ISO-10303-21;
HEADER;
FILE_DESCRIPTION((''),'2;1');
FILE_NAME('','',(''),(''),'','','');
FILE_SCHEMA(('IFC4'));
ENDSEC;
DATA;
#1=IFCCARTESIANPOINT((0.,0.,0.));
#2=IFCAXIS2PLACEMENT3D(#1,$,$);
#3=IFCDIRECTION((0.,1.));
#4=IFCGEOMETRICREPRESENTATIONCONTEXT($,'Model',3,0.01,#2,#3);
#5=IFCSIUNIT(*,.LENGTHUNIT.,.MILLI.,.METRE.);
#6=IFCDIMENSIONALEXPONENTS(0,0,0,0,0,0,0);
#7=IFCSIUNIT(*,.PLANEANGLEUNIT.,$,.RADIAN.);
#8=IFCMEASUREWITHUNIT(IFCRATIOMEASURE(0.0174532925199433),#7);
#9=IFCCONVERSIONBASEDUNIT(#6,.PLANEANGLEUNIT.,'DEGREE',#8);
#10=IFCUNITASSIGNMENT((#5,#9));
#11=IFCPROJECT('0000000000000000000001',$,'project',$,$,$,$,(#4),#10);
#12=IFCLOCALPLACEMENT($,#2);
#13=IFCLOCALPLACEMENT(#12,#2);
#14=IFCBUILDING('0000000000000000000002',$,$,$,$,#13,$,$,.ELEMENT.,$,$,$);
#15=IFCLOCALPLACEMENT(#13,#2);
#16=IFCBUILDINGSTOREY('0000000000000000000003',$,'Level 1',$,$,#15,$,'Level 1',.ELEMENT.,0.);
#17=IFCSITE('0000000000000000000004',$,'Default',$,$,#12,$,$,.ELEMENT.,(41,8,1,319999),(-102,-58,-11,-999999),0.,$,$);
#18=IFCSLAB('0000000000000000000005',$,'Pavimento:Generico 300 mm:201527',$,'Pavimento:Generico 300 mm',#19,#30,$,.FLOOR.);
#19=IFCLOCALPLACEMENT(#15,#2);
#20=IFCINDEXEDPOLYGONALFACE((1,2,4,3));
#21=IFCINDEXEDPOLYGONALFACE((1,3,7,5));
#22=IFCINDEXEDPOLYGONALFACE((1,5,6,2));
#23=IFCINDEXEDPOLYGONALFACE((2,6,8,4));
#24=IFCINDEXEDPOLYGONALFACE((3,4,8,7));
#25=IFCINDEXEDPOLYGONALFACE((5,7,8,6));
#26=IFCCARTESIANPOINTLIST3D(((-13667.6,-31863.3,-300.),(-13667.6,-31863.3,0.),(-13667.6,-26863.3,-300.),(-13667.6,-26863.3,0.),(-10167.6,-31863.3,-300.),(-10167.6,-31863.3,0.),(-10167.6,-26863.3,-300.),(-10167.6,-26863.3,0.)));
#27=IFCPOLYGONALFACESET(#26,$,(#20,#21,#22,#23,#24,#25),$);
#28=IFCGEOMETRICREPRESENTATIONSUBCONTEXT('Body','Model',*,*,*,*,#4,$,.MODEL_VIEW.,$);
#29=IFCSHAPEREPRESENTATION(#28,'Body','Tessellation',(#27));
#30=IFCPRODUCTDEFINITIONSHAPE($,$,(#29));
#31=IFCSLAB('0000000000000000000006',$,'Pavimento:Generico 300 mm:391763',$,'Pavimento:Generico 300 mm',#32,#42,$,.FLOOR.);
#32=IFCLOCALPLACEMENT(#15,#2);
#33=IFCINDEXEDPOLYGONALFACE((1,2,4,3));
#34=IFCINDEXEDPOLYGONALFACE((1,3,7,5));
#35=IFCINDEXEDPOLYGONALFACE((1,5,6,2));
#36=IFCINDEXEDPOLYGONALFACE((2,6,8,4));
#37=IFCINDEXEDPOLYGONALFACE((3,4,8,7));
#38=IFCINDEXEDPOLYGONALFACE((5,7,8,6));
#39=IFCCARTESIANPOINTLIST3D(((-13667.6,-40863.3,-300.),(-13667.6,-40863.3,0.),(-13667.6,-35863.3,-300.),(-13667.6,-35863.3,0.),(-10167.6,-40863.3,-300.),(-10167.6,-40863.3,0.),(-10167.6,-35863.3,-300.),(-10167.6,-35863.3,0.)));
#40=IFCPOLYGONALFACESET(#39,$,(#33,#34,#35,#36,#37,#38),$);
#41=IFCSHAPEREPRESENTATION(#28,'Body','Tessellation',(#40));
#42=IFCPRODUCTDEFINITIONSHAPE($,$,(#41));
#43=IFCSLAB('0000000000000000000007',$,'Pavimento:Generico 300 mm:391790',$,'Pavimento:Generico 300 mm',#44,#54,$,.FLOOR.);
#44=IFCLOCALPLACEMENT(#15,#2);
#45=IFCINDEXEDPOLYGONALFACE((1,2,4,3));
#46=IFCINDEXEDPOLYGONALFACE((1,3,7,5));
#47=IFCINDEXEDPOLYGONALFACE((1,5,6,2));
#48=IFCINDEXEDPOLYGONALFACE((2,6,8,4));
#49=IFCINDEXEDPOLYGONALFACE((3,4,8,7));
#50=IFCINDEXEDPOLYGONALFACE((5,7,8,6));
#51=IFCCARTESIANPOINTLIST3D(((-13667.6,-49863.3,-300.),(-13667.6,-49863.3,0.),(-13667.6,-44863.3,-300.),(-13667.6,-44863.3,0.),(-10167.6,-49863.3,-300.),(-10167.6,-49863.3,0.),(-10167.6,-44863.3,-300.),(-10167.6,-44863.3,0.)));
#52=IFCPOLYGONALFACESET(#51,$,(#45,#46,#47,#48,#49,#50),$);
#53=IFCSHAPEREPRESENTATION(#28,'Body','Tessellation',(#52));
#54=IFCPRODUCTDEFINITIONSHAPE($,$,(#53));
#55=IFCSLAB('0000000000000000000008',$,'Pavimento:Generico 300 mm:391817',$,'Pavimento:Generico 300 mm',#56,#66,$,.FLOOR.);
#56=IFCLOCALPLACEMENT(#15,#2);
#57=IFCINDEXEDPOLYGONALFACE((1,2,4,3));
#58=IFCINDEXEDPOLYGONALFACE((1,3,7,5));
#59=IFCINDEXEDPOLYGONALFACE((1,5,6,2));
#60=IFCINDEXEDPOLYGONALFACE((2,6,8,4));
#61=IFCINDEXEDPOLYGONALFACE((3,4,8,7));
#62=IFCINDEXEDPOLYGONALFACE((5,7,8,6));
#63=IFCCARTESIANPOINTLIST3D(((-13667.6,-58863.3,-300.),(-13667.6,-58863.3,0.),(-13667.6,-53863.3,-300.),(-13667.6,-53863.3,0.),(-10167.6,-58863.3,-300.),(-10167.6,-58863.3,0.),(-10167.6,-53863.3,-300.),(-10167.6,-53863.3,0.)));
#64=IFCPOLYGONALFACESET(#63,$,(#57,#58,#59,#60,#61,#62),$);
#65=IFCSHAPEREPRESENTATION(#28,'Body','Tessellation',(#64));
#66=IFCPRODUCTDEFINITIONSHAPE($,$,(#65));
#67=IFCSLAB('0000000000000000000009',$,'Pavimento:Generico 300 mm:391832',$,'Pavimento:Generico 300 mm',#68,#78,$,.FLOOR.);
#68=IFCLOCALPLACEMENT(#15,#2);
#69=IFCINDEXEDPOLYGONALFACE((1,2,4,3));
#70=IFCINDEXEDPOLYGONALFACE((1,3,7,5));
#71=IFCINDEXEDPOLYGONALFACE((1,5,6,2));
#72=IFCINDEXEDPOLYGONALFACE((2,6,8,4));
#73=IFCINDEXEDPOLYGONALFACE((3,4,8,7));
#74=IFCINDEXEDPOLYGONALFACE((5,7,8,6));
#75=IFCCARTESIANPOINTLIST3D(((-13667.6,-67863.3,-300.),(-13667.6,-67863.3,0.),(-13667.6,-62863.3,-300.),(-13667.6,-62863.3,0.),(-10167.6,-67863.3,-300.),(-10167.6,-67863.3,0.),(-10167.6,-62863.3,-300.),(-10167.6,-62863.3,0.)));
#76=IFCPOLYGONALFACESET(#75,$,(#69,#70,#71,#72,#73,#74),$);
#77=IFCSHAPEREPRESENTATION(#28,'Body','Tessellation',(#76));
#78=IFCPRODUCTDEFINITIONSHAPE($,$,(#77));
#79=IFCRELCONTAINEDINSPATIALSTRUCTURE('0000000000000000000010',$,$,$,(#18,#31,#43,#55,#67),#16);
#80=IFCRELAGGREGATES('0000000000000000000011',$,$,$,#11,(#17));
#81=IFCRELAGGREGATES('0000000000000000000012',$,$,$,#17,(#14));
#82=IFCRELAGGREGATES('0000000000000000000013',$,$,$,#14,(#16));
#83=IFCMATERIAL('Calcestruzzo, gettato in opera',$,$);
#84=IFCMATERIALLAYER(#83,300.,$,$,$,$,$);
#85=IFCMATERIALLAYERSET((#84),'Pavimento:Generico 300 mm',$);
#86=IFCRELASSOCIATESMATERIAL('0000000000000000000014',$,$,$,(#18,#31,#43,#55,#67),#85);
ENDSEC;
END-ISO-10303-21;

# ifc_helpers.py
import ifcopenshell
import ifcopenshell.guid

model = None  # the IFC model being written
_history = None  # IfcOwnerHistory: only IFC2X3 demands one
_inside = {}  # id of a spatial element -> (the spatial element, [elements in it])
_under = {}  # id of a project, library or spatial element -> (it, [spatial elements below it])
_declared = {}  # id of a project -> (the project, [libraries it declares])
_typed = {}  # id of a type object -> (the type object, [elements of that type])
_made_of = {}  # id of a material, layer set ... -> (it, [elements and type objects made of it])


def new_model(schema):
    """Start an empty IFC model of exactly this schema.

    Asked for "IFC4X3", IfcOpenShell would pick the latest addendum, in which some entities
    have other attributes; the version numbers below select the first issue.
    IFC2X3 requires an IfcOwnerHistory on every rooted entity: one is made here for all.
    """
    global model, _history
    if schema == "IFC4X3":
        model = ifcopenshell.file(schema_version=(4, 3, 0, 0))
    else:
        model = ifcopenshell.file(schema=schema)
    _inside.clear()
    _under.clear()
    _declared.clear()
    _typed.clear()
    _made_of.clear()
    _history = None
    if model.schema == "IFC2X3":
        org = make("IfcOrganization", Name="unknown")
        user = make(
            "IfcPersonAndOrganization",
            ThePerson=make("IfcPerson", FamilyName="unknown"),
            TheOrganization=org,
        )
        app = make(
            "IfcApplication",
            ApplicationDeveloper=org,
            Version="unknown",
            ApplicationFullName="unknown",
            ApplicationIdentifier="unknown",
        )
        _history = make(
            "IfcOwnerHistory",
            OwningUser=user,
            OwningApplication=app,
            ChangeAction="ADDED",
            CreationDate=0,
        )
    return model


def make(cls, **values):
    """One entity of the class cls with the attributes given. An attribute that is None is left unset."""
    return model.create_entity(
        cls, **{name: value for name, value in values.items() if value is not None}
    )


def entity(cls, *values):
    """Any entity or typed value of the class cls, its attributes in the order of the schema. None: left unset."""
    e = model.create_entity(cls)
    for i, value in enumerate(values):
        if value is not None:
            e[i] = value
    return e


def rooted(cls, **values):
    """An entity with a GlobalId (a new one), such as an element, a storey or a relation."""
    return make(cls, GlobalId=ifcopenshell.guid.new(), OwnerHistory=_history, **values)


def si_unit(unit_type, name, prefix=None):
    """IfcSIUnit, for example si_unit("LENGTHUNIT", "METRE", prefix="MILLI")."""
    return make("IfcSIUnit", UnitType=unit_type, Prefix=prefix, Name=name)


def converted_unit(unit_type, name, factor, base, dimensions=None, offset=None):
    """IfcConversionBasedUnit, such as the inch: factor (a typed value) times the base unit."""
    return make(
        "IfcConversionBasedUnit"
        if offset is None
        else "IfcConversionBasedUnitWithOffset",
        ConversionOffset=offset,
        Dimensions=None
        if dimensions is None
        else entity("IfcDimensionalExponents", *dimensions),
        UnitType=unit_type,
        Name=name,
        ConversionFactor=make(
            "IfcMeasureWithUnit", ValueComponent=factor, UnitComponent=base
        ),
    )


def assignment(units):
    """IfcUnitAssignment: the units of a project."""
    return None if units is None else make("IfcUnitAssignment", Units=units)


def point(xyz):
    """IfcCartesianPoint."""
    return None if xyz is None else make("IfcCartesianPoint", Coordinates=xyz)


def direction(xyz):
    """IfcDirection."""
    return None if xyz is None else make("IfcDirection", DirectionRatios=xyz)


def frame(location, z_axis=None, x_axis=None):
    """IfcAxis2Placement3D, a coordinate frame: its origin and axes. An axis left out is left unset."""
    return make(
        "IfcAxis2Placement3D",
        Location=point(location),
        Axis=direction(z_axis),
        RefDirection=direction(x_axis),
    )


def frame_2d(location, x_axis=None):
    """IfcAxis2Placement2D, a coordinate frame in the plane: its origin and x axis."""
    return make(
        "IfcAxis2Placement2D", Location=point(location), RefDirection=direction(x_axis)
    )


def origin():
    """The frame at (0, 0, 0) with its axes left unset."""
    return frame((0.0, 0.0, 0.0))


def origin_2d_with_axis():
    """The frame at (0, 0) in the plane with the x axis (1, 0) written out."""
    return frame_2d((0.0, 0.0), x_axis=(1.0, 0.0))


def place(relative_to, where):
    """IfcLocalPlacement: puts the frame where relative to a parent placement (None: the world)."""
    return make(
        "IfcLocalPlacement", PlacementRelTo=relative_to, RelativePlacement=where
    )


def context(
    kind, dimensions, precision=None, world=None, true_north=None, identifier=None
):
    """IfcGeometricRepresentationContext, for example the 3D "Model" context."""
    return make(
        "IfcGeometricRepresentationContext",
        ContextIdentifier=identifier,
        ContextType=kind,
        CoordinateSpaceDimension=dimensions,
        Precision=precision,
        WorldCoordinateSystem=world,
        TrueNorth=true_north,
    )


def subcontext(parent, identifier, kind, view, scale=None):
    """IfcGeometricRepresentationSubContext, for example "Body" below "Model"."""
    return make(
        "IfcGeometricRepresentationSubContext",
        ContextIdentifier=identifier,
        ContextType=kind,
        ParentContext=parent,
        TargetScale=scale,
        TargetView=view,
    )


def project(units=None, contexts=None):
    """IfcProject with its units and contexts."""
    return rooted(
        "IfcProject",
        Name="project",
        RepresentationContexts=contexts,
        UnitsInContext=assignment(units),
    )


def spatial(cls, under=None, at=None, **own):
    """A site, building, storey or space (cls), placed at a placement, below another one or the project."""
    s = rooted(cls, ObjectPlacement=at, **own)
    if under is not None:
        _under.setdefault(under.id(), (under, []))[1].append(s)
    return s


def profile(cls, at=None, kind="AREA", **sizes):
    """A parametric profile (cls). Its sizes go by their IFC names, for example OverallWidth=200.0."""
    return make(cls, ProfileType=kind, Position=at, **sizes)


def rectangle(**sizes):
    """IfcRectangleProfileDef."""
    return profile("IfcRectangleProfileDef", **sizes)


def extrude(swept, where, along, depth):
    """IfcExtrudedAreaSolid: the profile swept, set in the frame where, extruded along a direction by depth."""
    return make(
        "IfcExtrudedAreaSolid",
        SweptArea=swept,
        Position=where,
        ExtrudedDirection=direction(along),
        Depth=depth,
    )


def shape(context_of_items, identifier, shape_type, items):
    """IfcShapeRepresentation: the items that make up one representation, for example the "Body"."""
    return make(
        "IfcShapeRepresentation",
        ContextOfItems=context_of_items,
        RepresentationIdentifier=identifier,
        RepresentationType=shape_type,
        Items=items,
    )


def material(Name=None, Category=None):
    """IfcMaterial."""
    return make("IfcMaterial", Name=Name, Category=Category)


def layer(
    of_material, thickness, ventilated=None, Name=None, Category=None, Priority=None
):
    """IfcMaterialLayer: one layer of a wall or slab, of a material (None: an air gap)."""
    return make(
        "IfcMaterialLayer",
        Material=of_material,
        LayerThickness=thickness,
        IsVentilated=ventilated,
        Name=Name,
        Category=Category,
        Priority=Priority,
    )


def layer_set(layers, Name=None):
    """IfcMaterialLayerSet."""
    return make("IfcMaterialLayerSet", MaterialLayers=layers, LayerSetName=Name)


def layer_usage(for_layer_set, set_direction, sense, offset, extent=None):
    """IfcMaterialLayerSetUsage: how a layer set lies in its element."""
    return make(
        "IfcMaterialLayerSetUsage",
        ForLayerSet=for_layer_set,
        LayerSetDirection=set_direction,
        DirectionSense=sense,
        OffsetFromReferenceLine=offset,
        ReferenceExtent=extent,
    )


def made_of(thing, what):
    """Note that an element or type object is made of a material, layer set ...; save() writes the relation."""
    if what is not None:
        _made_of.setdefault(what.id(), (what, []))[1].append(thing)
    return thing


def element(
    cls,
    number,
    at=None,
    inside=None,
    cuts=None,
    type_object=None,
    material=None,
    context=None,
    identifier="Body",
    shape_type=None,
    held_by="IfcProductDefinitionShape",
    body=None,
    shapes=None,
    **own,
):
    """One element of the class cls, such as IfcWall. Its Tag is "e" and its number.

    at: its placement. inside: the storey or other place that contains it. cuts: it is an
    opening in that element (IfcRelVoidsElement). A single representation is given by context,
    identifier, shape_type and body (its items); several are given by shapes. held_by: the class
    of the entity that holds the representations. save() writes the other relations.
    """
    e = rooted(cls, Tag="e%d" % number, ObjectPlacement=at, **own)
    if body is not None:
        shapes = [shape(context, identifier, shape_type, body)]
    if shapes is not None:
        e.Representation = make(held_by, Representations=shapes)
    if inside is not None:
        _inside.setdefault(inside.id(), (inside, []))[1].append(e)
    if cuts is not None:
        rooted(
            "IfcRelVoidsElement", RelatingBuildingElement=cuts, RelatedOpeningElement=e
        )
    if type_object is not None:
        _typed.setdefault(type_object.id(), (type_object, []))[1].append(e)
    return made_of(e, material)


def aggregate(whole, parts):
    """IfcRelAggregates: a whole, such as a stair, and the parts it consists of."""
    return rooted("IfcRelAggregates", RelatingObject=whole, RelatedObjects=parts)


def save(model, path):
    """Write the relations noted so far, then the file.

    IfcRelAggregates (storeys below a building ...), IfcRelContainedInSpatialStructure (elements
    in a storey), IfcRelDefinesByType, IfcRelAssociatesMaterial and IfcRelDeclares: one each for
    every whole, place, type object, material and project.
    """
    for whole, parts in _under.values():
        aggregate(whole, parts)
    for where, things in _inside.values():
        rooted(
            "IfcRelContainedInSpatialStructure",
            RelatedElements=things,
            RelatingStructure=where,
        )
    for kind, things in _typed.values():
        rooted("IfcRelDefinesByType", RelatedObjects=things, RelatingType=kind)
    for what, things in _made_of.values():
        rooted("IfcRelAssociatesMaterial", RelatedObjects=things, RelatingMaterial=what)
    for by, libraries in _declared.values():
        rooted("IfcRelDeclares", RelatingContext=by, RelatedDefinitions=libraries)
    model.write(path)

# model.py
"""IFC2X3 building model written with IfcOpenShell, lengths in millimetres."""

from ifc_helpers import new_model, entity, si_unit, converted_unit, direction, frame, frame_2d, origin, origin_2d_with_axis, place, context, subcontext, project, spatial, rectangle, extrude, material, layer, layer_set, layer_usage, element, save


model = new_model("IFC2X3")

# Units and contexts
model_context = context("Model", 3, precision=0.01, world=origin(), true_north=direction((0.0, 1.0)))
body_context = subcontext(model_context, "Body", "Model", "MODEL_VIEW")
ifc_project = project(units=[si_unit("LENGTHUNIT", "METRE", prefix="MILLI"), converted_unit("PLANEANGLEUNIT", "DEGREE", entity("IfcRatioMeasure", 0.0174532925199433), si_unit("PLANEANGLEUNIT", "RADIAN"), dimensions=[0, 0, 0, 0, 0, 0, 0])], contexts=[model_context])

# Site, building, storey
site_placement = place(None, origin())
site = spatial("IfcSite", under=ifc_project, at=site_placement, Name="Default", CompositionType="ELEMENT", RefLatitude=(41, 8, 1, 319999), RefLongitude=(-102, -58, -11, -999999), RefElevation=0.0)
building_placement = place(site_placement, origin())
building = spatial("IfcBuilding", under=site, at=building_placement, CompositionType="ELEMENT")
storey_placement = place(building_placement, origin())
storey = spatial("IfcBuildingStorey", under=building, at=storey_placement, Name="Level 1", LongName="Level 1", CompositionType="ELEMENT", Elevation=0.0)

# Slabs
ifc_material = material(Name="Calcestruzzo, gettato in opera")
ifc_layer = layer(ifc_material, 300.0)
ifc_layer_set = layer_set([ifc_layer], Name="Pavimento:Generico 300 mm")
ifc_layer_usage_1 = layer_usage(ifc_layer_set, "AXIS3", "POSITIVE", 0.0)
slab_1_placement = place(storey_placement, origin())
element("IfcSlab", 1, at=slab_1_placement, inside=storey, material=ifc_layer_usage_1, Name="Pavimento:Generico 300 mm:201527", ObjectType="Pavimento:Generico 300 mm", PredefinedType="FLOOR", context=body_context, shape_type="SweptSolid", body=[
    extrude(rectangle(XDim=5000.0, YDim=3500.0, at=frame_2d((0.0, 0.0), x_axis=(1.0, 0.0))), frame((-11917.6, -29363.3, 0.0), z_axis=(0.0, 0.0, -1.0), x_axis=(0.0, 1.0, 0.0)), (0.0, 0.0, 1.0), 300.0),
])
ifc_layer_usage_2 = layer_usage(ifc_layer_set, "AXIS3", "POSITIVE", 0.0)
slab_2_placement = place(storey_placement, origin())
element("IfcSlab", 2, at=slab_2_placement, inside=storey, material=ifc_layer_usage_2, Name="Pavimento:Generico 300 mm:391763", ObjectType="Pavimento:Generico 300 mm", PredefinedType="FLOOR", context=body_context, shape_type="SweptSolid", body=[
    extrude(rectangle(XDim=5000.0, YDim=3500.0, at=frame_2d((0.0, 0.0), x_axis=(1.0, 0.0))), frame((-11917.6, -38363.3, 0.0), z_axis=(0.0, 0.0, -1.0), x_axis=(0.0, 1.0, 0.0)), (0.0, 0.0, 1.0), 300.0),
])
ifc_layer_usage_3 = layer_usage(ifc_layer_set, "AXIS3", "POSITIVE", 0.0)
slab_3_placement = place(storey_placement, origin())
element("IfcSlab", 3, at=slab_3_placement, inside=storey, material=ifc_layer_usage_3, Name="Pavimento:Generico 300 mm:391790", ObjectType="Pavimento:Generico 300 mm", PredefinedType="FLOOR", context=body_context, shape_type="SweptSolid", body=[
    extrude(rectangle(XDim=5000.0, YDim=3500.0, at=origin_2d_with_axis()), frame((-11917.6, -47363.3, 0.0), z_axis=(0.0, 0.0, -1.0), x_axis=(0.0, 1.0, 0.0)), (0.0, 0.0, 1.0), 300.0),
])
ifc_layer_usage_4 = layer_usage(ifc_layer_set, "AXIS3", "POSITIVE", 0.0)
slab_4_placement = place(storey_placement, origin())
element("IfcSlab", 4, at=slab_4_placement, inside=storey, material=ifc_layer_usage_4, Name="Pavimento:Generico 300 mm:391817", ObjectType="Pavimento:Generico 300 mm", PredefinedType="FLOOR", context=body_context, shape_type="SweptSolid", body=[
    extrude(rectangle(XDim=5000.0, YDim=3500.0, at=origin_2d_with_axis()), frame((-11917.6, -56363.3, 0.0), z_axis=(0.0, 0.0, -1.0), x_axis=(0.0, 1.0, 0.0)), (0.0, 0.0, 1.0), 300.0),
])
ifc_layer_usage_5 = layer_usage(ifc_layer_set, "AXIS3", "POSITIVE", 0.0)
slab_5_placement = place(storey_placement, origin())
element("IfcSlab", 5, at=slab_5_placement, inside=storey, material=ifc_layer_usage_5, Name="Pavimento:Generico 300 mm:391832", ObjectType="Pavimento:Generico 300 mm", PredefinedType="FLOOR", context=body_context, shape_type="SweptSolid", body=[
    extrude(rectangle(XDim=5000.0, YDim=3500.0, at=origin_2d_with_axis()), frame((-11917.6, -65363.3, 0.0), z_axis=(0.0, 0.0, -1.0), x_axis=(0.0, 1.0, 0.0)), (0.0, 0.0, 1.0), 300.0),
])

save(model, "model.ifc")
